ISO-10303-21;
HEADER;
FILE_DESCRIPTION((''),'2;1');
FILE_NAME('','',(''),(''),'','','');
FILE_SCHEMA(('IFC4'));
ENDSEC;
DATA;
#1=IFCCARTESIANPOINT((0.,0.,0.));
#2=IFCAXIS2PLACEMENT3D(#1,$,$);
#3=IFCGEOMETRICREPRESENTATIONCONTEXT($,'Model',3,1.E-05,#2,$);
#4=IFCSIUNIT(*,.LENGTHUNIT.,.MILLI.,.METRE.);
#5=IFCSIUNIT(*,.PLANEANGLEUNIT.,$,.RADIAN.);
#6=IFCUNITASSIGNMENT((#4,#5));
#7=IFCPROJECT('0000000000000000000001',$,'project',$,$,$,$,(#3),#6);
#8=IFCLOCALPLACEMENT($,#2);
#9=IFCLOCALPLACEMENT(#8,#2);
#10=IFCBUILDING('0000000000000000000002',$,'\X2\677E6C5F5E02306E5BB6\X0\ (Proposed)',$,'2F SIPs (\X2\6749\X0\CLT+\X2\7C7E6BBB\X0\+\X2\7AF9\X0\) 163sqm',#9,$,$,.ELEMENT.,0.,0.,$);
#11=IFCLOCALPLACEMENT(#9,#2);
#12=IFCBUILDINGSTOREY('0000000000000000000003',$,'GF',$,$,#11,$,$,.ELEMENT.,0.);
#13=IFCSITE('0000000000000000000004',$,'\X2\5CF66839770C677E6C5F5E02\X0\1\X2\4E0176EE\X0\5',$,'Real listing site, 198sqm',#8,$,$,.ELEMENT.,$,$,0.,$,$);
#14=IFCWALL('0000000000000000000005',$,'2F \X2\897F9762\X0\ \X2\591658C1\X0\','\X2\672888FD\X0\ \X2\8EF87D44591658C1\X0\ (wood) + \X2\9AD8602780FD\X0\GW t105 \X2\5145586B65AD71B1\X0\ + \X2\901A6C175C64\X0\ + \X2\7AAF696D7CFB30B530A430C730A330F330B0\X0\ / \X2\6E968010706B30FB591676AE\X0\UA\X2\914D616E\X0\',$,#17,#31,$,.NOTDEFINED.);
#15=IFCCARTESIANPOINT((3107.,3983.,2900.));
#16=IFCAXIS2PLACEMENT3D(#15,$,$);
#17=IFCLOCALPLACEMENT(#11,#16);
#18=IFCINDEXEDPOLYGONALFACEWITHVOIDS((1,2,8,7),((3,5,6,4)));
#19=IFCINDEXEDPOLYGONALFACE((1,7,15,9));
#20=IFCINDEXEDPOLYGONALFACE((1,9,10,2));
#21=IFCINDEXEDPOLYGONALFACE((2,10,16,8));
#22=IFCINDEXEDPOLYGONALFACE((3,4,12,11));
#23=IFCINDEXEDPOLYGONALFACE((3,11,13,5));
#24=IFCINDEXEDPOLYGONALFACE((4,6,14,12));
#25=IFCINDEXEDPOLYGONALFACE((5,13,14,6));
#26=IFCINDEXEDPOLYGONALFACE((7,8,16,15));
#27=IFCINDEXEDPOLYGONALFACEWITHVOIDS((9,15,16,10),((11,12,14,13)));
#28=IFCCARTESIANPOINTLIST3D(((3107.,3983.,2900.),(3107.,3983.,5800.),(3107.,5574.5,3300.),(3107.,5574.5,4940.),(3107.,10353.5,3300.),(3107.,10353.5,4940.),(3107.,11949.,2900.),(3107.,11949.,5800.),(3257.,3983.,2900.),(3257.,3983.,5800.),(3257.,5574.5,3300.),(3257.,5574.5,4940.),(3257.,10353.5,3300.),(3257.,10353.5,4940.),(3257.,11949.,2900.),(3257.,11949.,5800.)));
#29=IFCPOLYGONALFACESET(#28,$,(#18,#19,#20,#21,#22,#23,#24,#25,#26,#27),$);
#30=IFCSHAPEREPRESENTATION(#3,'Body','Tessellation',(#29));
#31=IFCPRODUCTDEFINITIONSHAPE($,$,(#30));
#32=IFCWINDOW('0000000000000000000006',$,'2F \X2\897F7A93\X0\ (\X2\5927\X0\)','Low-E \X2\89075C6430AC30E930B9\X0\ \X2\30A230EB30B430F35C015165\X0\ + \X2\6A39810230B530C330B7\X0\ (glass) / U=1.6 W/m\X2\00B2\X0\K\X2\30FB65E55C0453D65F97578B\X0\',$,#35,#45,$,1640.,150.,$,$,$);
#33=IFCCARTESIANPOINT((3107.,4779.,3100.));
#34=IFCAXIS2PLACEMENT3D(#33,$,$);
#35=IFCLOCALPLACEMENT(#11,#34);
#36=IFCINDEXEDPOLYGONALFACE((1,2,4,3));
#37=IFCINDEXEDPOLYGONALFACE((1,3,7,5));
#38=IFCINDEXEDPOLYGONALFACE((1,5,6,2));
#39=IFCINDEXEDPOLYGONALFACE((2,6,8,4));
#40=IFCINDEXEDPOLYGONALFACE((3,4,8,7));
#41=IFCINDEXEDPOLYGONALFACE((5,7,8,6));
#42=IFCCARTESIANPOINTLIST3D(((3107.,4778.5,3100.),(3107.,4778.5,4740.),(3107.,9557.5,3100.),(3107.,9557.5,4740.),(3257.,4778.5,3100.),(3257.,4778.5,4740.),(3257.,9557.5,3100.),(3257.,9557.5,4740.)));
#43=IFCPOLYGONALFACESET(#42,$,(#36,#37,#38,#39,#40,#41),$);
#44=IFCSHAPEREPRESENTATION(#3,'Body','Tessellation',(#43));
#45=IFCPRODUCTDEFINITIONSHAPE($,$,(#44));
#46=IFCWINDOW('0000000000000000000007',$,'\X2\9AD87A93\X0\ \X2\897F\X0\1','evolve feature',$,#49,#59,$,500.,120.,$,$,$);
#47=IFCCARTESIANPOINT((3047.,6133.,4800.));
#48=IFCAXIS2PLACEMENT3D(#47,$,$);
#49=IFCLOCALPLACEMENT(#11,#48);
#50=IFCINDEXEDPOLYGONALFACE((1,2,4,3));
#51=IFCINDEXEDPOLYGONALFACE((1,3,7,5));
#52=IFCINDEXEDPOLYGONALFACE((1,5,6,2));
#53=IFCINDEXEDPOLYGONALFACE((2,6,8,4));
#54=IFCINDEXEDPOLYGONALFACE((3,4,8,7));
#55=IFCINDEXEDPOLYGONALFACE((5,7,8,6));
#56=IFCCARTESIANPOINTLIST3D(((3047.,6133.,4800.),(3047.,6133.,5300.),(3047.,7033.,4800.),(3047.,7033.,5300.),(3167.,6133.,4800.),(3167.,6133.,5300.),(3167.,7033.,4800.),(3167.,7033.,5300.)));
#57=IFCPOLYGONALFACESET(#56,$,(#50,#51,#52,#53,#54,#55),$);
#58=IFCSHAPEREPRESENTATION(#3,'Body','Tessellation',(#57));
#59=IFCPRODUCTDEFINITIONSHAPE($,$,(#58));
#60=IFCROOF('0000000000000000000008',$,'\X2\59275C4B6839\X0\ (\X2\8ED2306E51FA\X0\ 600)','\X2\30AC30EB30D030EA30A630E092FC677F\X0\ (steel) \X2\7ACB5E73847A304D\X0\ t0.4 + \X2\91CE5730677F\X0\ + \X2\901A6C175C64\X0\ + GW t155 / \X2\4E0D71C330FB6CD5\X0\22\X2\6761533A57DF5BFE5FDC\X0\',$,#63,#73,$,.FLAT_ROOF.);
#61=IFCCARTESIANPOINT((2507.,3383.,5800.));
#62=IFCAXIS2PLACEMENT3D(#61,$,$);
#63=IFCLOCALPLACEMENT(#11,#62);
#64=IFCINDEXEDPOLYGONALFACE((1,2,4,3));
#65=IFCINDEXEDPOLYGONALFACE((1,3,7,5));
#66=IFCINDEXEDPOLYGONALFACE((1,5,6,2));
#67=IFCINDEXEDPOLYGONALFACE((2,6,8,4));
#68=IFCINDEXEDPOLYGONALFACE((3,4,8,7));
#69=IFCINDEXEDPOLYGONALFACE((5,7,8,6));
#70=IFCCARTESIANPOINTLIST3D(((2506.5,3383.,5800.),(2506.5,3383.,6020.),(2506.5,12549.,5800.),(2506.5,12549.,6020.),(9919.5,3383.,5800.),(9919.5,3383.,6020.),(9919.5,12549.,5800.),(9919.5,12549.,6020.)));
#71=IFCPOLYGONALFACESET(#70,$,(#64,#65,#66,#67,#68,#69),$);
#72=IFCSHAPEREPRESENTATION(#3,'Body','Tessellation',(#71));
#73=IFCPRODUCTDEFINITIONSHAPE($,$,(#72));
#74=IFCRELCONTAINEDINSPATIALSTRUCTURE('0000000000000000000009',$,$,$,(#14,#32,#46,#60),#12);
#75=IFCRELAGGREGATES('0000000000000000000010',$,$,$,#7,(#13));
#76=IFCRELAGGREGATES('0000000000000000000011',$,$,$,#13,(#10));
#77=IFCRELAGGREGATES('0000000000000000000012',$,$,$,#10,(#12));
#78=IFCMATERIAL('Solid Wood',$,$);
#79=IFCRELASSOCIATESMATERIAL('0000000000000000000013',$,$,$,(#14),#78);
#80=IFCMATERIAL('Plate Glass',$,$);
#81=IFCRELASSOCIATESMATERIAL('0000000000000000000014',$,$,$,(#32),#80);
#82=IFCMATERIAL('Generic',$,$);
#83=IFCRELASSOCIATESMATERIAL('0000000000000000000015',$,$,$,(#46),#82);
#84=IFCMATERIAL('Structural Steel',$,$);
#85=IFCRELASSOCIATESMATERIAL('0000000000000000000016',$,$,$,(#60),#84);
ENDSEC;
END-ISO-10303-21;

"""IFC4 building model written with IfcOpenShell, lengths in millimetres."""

from ifc_helpers import new_model, si_unit, frame, frame_2d, origin, place, context, project, spatial, rectangle, extrude, material, element, fill, save


model = new_model("IFC4")

# Units and contexts
model_context = context("Model", 3, precision=1e-05, world=origin())
ifc_project = project(units=[si_unit("LENGTHUNIT", "METRE", prefix="MILLI"), si_unit("PLANEANGLEUNIT", "RADIAN")], contexts=[model_context])

# Site, building, storey
site_placement = place(None, origin())
site = spatial("IfcSite", under=ifc_project, at=site_placement, Name="島根県松江市1丁目5", ObjectType="Real listing site, 198sqm", CompositionType="ELEMENT", RefElevation=0.0)
building_placement = place(site_placement, origin())
building = spatial("IfcBuilding", under=site, at=building_placement, Name="松江市の家 (Proposed)", ObjectType="2F SIPs (杉CLT+籾殻+竹) 163sqm", CompositionType="ELEMENT", ElevationOfRefHeight=0.0, ElevationOfTerrain=0.0)
storey_placement = place(building_placement, origin())
storey = spatial("IfcBuildingStorey", under=building, at=storey_placement, Name="GF", CompositionType="ELEMENT", Elevation=0.0)

# Shared definitions
ifc_material_1 = material(Name="Solid Wood")
ifc_material_2 = material(Name="Generic")

# Shared definitions
ifc_material_3 = material(Name="Plate Glass")

# Wall, openings, windows
wall_1_placement = place(storey_placement, frame((3107.0, 3983.0, 2900.0)))
wall_1 = element("IfcWall", 1, at=wall_1_placement, inside=storey, material=ifc_material_1, Name="2F 西面 外壁", Description="木製 軸組外壁 (wood) + 高性能GW t105 充填断熱 + 通気層 + 窯業系サイディング / 準耐火・外皮UA配慮", PredefinedType="NOTDEFINED", context=model_context, shape_type="SweptSolid", body=[
    extrude(rectangle(XDim=150.0, YDim=7966.0, at=frame_2d((75.0, 3983.0))), frame((3107.0, 3983.0, 2900.0)), (0.0, 0.0, 1.0), 2900.0),
])
opening_1_placement = place(storey_placement, frame((3107.0, 4779.0, 3100.0)))
opening_1 = element("IfcOpeningElement", 2, at=opening_1_placement, cuts=wall_1, PredefinedType="NOTDEFINED", context=model_context, shape_type="SweptSolid", body=[
    extrude(rectangle(XDim=150.0, YDim=4779.0, at=frame_2d((75.0, 2389.0))), frame((3107.0, 4779.0, 3100.0)), (0.0, 0.0, 1.0), 1640.0),
])
opening_2_placement = place(storey_placement, frame((3047.0, 6133.0, 4800.0)))
opening_2 = element("IfcOpeningElement", 3, at=opening_2_placement, cuts=wall_1, PredefinedType="NOTDEFINED", context=model_context, shape_type="SweptSolid", body=[
    extrude(rectangle(XDim=120.0, YDim=900.0, at=frame_2d((60.0, 450.0))), frame((3047.0, 6133.0, 4800.0)), (0.0, 0.0, 1.0), 500.0),
])
window_1_placement = place(storey_placement, frame((3107.0, 4779.0, 3100.0)))
window_1 = element("IfcWindow", 4, at=window_1_placement, inside=storey, material=ifc_material_3, Name="2F 西窓 (大)", Description="Low-E 複層ガラス アルゴン封入 + 樹脂サッシ (glass) / U=1.6 W/m²K・日射取得型", OverallHeight=1640.0, OverallWidth=150.0, context=model_context, shape_type="SweptSolid", body=[
    extrude(rectangle(XDim=150.0, YDim=4779.0, at=frame_2d((75.0, 2389.0))), frame((3107.0, 4779.0, 3100.0)), (0.0, 0.0, 1.0), 1640.0),
])
fill(opening_1, window_1)
window_2_placement = place(storey_placement, frame((3047.0, 6133.0, 4800.0)))
window_2 = element("IfcWindow", 5, at=window_2_placement, inside=storey, material=ifc_material_2, Name="高窓 西1", Description="evolve feature", OverallHeight=500.0, OverallWidth=120.0, context=model_context, shape_type="SweptSolid", body=[
    extrude(rectangle(XDim=120.0, YDim=900.0, at=frame_2d((60.0, 450.0))), frame((3047.0, 6133.0, 4800.0)), (0.0, 0.0, 1.0), 500.0),
])
fill(opening_2, window_2)

# Roof
ifc_material_4 = material(Name="Structural Steel")
roof_1_placement = place(storey_placement, frame((2507.0, 3383.0, 5800.0)))
element("IfcRoof", 6, at=roof_1_placement, inside=storey, material=ifc_material_4, Name="大屋根 (軒の出 600)", Description="ガルバリウム鋼板 (steel) 立平葺き t0.4 + 野地板 + 通気層 + GW t155 / 不燃・法22条区域対応", PredefinedType="FLAT_ROOF", context=model_context, shape_type="SweptSolid", body=[
    extrude(rectangle(XDim=7413.0, YDim=9166.0, at=frame_2d((3706.0, 4583.0))), frame((2507.0, 3383.0, 5800.0)), (0.0, 0.0, 1.0), 220.0),
])

save(model, "model.ifc")
